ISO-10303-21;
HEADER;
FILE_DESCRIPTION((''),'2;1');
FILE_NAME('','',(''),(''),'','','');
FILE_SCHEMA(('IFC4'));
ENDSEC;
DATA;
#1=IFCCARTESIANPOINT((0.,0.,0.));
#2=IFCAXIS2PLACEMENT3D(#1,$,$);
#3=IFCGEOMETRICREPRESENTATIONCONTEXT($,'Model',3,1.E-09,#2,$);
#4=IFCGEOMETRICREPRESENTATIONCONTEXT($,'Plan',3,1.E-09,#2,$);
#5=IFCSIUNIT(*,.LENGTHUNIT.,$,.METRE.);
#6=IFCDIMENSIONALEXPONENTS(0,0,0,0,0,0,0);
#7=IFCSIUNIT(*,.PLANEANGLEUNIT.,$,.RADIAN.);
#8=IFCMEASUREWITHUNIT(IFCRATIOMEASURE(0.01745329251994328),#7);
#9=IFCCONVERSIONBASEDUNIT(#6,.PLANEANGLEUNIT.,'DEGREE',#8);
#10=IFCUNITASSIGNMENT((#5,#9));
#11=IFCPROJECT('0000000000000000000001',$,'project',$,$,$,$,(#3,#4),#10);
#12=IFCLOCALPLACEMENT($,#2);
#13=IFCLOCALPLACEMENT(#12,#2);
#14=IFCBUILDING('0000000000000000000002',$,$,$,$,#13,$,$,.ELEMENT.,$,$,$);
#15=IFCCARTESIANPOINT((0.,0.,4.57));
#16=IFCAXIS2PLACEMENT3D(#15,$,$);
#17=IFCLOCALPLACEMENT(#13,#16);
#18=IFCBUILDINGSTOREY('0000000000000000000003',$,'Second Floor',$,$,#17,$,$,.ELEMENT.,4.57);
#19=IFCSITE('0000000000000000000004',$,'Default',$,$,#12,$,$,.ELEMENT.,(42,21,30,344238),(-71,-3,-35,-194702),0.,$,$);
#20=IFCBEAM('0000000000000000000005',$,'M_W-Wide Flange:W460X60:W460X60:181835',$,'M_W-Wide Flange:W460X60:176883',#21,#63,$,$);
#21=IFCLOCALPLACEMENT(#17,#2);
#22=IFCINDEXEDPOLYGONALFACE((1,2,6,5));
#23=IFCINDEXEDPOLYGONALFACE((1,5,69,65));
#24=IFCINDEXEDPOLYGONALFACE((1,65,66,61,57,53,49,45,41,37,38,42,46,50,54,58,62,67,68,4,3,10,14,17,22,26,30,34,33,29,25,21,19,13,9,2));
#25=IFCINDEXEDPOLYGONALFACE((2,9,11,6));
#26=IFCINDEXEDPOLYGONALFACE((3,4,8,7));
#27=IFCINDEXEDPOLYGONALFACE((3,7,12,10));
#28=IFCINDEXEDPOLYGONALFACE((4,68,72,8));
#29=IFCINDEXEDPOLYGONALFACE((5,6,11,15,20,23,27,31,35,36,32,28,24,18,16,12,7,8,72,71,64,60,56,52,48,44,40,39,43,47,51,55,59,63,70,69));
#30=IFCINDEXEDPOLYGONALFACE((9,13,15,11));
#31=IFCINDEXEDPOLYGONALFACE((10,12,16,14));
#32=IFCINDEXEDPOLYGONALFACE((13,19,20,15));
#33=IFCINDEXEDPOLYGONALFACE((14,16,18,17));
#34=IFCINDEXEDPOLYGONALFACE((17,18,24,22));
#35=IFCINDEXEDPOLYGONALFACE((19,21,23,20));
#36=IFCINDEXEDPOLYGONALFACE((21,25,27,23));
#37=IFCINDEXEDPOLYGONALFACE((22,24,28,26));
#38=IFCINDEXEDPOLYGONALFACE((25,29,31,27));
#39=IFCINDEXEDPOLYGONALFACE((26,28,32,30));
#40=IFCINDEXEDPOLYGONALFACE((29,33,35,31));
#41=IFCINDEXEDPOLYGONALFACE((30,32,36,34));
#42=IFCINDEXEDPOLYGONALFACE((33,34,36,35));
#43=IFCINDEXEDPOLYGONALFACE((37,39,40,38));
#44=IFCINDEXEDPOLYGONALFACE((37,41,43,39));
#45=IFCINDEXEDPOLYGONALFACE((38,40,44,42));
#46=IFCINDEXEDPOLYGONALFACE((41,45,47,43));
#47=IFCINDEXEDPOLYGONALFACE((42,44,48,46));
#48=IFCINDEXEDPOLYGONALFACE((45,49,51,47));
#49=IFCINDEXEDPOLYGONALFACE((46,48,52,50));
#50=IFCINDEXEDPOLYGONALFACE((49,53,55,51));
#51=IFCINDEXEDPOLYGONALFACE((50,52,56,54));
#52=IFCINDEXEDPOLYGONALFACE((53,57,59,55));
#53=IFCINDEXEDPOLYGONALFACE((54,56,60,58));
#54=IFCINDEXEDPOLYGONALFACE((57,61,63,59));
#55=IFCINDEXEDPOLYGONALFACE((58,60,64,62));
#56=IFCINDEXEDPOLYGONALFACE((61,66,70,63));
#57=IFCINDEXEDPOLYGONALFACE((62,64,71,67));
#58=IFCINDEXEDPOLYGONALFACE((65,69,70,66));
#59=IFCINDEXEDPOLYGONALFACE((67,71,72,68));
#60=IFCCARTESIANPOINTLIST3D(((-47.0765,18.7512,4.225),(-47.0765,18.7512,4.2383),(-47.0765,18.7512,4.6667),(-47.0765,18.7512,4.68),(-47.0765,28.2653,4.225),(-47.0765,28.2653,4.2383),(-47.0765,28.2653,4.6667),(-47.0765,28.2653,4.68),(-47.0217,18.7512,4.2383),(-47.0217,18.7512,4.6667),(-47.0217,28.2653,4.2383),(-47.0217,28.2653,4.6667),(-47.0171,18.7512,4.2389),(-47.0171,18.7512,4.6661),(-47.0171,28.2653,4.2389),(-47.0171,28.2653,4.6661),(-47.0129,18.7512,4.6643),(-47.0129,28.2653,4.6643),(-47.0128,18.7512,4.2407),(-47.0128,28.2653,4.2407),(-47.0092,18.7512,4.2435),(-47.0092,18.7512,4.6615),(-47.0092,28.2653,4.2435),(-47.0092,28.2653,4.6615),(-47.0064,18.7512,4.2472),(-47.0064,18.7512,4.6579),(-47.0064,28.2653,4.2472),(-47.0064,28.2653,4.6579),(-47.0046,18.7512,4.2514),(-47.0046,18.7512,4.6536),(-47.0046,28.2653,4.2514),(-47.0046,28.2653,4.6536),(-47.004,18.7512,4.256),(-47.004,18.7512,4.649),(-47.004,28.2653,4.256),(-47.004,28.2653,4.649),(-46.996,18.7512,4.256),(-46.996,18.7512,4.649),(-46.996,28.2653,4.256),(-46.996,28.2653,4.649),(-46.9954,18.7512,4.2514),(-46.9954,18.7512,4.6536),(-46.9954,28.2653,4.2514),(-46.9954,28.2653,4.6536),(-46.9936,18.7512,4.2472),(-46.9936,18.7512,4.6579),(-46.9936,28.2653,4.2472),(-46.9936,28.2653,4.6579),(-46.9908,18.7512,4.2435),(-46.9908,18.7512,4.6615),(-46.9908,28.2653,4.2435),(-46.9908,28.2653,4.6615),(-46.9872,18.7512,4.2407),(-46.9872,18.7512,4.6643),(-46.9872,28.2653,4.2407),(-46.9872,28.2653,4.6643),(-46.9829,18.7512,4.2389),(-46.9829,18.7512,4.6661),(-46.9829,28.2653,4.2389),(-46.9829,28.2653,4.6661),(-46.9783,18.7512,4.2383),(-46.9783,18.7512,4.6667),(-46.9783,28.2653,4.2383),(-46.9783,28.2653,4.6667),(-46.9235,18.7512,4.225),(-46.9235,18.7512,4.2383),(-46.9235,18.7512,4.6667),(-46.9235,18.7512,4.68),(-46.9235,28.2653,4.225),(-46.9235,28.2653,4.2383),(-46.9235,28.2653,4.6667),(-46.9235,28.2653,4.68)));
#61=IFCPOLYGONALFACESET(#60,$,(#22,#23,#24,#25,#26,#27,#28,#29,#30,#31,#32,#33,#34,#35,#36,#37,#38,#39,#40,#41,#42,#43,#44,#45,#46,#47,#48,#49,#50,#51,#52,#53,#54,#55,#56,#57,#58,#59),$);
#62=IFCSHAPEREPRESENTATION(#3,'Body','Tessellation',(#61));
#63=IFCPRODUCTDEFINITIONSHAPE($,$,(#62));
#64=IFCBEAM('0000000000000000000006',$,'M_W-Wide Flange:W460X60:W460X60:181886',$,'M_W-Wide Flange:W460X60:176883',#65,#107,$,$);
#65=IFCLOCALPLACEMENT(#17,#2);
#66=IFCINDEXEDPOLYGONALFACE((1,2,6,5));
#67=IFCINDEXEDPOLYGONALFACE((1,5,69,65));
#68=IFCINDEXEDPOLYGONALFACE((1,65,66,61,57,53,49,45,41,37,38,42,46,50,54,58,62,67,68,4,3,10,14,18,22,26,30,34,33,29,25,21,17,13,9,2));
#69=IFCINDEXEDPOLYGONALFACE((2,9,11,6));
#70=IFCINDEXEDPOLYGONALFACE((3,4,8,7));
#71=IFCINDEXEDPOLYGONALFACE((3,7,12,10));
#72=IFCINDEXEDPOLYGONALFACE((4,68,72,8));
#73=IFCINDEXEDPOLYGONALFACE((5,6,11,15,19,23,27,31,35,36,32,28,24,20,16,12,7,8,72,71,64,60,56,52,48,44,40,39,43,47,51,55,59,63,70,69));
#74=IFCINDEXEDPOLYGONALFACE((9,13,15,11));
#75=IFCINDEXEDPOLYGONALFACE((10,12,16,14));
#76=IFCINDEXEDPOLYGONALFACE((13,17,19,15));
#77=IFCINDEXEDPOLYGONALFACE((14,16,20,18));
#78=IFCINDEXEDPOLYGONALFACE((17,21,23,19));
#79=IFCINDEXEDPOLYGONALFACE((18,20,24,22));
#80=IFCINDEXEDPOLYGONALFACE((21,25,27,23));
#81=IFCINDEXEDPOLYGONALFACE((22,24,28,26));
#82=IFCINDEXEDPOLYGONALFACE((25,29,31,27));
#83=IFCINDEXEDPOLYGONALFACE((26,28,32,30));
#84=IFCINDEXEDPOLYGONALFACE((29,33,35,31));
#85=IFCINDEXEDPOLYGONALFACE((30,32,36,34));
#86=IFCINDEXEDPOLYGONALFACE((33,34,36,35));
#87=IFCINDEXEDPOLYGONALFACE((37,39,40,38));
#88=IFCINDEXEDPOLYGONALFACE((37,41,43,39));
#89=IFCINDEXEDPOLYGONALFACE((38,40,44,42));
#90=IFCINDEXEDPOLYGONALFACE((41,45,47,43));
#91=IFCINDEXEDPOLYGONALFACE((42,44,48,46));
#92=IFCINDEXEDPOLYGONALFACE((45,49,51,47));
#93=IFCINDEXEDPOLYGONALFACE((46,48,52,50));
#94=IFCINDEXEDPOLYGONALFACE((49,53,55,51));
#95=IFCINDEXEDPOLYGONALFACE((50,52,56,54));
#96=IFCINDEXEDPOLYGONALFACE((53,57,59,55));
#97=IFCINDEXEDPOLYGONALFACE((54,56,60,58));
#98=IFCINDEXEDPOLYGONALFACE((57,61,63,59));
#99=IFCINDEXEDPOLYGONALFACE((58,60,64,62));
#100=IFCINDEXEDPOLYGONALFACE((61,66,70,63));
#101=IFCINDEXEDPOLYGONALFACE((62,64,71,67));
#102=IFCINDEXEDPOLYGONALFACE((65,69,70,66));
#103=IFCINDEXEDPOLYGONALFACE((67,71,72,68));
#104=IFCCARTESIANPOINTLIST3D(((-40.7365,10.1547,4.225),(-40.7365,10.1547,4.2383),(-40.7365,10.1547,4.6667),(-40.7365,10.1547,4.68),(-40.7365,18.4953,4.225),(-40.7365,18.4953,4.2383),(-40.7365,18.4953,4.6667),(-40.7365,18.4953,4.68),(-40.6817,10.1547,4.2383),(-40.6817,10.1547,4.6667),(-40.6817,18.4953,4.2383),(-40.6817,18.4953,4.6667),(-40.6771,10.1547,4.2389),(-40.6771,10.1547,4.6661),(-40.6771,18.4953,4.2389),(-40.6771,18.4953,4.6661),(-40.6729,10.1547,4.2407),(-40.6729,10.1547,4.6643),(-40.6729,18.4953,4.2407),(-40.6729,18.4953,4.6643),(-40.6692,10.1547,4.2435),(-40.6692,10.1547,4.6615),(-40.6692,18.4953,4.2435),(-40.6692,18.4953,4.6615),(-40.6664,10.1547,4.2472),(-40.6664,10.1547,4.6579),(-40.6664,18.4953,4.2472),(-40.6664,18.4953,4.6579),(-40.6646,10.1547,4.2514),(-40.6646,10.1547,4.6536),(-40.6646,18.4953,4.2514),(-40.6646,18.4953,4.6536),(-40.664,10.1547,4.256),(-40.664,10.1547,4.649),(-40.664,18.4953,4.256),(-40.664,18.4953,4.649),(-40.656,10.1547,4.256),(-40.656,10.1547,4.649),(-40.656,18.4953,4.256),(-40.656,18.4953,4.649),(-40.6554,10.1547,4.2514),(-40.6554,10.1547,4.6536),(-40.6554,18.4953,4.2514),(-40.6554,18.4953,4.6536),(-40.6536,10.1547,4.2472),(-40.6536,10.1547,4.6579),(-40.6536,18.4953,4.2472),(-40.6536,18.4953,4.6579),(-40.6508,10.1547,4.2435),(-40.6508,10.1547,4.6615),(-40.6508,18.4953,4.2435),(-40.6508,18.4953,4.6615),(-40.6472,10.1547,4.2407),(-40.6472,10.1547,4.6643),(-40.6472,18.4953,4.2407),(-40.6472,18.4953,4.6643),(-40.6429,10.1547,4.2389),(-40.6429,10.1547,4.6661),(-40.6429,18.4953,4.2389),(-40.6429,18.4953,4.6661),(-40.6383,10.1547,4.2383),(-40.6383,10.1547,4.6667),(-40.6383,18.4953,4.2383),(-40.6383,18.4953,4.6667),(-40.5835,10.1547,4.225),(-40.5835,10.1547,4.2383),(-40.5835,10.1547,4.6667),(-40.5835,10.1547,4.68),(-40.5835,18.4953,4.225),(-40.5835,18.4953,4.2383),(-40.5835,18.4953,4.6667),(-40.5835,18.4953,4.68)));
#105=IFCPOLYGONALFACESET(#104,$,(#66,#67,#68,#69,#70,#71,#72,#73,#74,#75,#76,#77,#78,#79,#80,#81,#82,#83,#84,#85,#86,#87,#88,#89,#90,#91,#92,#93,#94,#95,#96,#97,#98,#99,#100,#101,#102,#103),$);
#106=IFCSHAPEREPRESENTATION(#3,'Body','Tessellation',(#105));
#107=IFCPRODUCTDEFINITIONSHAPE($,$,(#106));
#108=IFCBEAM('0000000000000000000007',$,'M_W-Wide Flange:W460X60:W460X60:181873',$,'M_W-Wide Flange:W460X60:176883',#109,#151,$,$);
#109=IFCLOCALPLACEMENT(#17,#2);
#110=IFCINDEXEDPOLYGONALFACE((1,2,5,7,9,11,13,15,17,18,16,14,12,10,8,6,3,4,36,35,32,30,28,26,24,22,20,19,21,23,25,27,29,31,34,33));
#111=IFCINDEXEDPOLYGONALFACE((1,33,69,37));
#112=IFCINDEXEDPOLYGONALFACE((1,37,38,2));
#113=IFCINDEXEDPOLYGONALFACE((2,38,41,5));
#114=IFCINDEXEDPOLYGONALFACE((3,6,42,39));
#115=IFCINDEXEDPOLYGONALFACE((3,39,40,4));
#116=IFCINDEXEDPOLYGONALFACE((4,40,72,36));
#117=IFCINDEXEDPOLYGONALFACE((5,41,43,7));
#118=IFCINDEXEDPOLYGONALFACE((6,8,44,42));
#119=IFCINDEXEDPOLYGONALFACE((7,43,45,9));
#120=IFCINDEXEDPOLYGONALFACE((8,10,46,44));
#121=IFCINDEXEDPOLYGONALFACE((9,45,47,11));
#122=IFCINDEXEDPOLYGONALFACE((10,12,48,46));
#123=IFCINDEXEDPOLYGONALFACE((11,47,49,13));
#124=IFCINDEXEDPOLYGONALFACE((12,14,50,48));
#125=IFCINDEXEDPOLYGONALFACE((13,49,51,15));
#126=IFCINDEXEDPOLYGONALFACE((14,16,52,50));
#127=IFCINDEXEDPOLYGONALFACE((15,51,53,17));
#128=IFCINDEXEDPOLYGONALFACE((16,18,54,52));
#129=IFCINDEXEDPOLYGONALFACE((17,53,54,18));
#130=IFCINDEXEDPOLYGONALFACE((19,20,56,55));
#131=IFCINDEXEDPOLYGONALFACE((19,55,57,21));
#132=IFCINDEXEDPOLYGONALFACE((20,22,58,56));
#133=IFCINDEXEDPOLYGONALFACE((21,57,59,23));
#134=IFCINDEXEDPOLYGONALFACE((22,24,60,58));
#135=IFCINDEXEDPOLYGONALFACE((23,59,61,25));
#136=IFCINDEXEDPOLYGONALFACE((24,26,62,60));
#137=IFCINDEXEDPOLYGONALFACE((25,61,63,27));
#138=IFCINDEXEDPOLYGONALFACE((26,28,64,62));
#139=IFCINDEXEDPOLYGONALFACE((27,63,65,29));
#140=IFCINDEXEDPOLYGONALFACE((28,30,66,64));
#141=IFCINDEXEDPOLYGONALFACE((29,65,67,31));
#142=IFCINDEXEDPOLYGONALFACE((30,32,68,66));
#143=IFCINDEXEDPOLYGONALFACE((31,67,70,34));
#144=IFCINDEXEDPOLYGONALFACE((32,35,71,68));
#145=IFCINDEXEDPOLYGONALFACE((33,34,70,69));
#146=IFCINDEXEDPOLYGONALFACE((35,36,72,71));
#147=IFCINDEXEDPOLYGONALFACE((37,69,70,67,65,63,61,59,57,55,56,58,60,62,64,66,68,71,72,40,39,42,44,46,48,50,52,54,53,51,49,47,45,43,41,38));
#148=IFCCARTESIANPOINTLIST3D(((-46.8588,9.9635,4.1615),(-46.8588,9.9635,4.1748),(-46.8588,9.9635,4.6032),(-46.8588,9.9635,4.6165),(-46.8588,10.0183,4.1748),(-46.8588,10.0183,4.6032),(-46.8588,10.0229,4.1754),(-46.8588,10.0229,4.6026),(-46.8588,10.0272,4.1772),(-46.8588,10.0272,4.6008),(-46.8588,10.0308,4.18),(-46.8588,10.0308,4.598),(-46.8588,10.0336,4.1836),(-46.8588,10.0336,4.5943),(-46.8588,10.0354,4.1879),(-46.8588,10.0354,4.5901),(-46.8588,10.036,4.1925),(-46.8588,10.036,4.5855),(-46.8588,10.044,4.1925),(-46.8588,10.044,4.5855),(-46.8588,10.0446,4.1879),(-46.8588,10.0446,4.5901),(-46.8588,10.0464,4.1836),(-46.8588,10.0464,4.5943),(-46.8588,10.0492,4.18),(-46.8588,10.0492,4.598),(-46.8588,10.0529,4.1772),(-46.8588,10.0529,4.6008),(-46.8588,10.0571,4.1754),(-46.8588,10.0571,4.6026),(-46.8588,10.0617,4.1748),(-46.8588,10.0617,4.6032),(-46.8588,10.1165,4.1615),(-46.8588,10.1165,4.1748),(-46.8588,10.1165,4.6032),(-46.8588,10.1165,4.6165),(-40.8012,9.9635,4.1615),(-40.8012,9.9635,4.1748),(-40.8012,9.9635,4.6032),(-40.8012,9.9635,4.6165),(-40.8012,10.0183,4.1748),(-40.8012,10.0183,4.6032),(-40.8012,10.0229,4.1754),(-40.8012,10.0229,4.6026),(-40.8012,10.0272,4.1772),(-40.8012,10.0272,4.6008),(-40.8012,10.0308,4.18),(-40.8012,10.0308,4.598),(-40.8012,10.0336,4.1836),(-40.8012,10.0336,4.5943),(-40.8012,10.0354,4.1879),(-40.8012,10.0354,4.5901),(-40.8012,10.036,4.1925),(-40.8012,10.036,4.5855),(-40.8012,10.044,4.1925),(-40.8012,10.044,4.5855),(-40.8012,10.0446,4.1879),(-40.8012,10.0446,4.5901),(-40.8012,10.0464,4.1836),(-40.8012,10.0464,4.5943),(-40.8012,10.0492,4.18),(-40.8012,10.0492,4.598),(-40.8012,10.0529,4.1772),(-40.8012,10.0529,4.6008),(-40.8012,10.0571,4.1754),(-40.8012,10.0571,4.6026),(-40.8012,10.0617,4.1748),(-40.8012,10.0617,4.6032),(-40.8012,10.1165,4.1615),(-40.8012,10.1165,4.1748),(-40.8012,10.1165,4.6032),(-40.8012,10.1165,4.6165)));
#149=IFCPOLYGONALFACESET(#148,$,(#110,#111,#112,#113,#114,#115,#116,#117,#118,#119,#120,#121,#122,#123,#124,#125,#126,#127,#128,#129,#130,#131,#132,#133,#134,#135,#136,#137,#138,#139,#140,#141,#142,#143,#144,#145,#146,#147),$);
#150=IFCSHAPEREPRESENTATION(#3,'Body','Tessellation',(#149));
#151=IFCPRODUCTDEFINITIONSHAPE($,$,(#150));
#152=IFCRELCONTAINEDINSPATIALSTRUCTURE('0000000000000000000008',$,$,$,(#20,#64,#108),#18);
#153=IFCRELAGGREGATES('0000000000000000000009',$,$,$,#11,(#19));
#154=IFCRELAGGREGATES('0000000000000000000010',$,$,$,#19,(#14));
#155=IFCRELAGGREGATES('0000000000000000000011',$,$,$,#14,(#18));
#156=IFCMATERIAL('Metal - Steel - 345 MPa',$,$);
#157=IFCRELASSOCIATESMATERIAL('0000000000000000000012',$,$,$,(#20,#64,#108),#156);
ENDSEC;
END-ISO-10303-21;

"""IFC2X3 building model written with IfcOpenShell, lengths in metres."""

from ifc_helpers import new_model, entity, si_unit, converted_unit, frame, frame_2d, origin, place, context, project, spatial, polyline, circle_curve, parameter, trimmed, segment, composite_curve, outline, extrude, material, element, save


model = new_model("IFC2X3")

# Units and contexts
model_context = context("Model", 3, precision=1e-09, world=origin())
plan_context = context("Plan", 3, precision=1e-09, world=origin())
ifc_project = project(units=[si_unit("LENGTHUNIT", "METRE"), converted_unit("PLANEANGLEUNIT", "DEGREE", entity("IfcRatioMeasure", 0.01745329251994328), si_unit("PLANEANGLEUNIT", "RADIAN"), dimensions=[0, 0, 0, 0, 0, 0, 0])], contexts=[model_context, plan_context])

# Site, building, storey
site_placement = place(None, origin())
site = spatial("IfcSite", under=ifc_project, at=site_placement, Name="Default", CompositionType="ELEMENT", RefLatitude=(42, 21, 30, 344238), RefLongitude=(-71, -3, -35, -194702), RefElevation=0.0)
building_placement = place(site_placement, origin())
building = spatial("IfcBuilding", under=site, at=building_placement, CompositionType="ELEMENT")
storey_placement = place(building_placement, frame((0.0, 0.0, 4.57)))
storey = spatial("IfcBuildingStorey", under=building, at=storey_placement, Name="Second Floor", CompositionType="ELEMENT", Elevation=4.57)

# Shared definitions
ifc_material_1 = material(Name="Metal - Steel - 345 MPa")

# Beams
beam_1_placement = place(storey_placement, frame((-47.0, 28.3781, 4.68), z_axis=(0.0, 0.0, 1.0), x_axis=(-1.0, 0.0, 0.0)))
element("IfcBeam", 1, at=beam_1_placement, inside=storey, material=ifc_material_1, Name="M_W-Wide Flange:W460X60:W460X60:181835", ObjectType="M_W-Wide Flange:W460X60:176883", context=model_context, shape_type="SweptSolid", body=[
    extrude(outline(composite_curve([segment(polyline([(0.2142, -0.0765), (0.2275, -0.0765)]), True, "CONTINUOUS"), segment(polyline([(0.2275, -0.0765), (0.2275, 0.0765)]), True, "CONTINUOUS"), segment(polyline([(0.2275, 0.0765), (0.2142, 0.0765)]), True, "CONTINUOUS"), segment(polyline([(0.2142, 0.0765), (0.2142, 0.0217)]), True, "CONTINUOUS"), segment(trimmed(circle_curve(frame_2d((0.1965, 0.0217), x_axis=(1.0, 0.0)), 0.0177), [parameter(270.0)], [parameter(360.0)], True, "PARAMETER"), False, "CONTINUOUS"), segment(polyline([(0.1965, 0.004), (-0.1965, 0.004)]), True, "CONTINUOUS"), segment(trimmed(circle_curve(frame_2d((-0.1965, 0.0217), x_axis=(0.0, -1.0)), 0.0177), [parameter(270.0)], [parameter(360.0)], True, "PARAMETER"), False, "CONTINUOUS"), segment(polyline([(-0.2142, 0.0217), (-0.2142, 0.0765)]), True, "CONTINUOUS"), segment(polyline([(-0.2142, 0.0765), (-0.2275, 0.0765)]), True, "CONTINUOUS"), segment(polyline([(-0.2275, 0.0765), (-0.2275, -0.0765)]), True, "CONTINUOUS"), segment(polyline([(-0.2275, -0.0765), (-0.2142, -0.0765)]), True, "CONTINUOUS"), segment(polyline([(-0.2142, -0.0765), (-0.2142, -0.0217)]), True, "CONTINUOUS"), segment(trimmed(circle_curve(frame_2d((-0.1965, -0.0217), x_axis=(-1.0, 0.0)), 0.0177), [parameter(270.0)], [parameter(360.0)], True, "PARAMETER"), False, "CONTINUOUS"), segment(polyline([(-0.1965, -0.004), (0.1965, -0.004)]), True, "CONTINUOUS"), segment(trimmed(circle_curve(frame_2d((0.1965, -0.0217), x_axis=(0.0, 1.0)), 0.0177), [parameter(270.0)], [parameter(0.0)], True, "PARAMETER"), False, "CONTINUOUS"), segment(polyline([(0.2142, -0.0217), (0.2142, -0.0765)]), True, "CONTINUOUS")], self_intersect=False)), frame((0.0, 9.6269, -0.2275), z_axis=(0.0, -1.0, 0.0), x_axis=(0.0, 0.0, -1.0)), (0.0, 0.0, 1.0), 9.5141),
])
beam_2_placement = place(storey_placement, frame((-40.66, 10.0422, 4.68)))
element("IfcBeam", 2, at=beam_2_placement, inside=storey, material=ifc_material_1, Name="M_W-Wide Flange:W460X60:W460X60:181886", ObjectType="M_W-Wide Flange:W460X60:176883", context=model_context, shape_type="SweptSolid", body=[
    extrude(outline(composite_curve([segment(polyline([(-0.0765, -0.2142), (-0.0765, -0.2275)]), True, "CONTINUOUS"), segment(polyline([(-0.0765, -0.2275), (0.0765, -0.2275)]), True, "CONTINUOUS"), segment(polyline([(0.0765, -0.2275), (0.0765, -0.2142)]), True, "CONTINUOUS"), segment(polyline([(0.0765, -0.2142), (0.0217, -0.2142)]), True, "CONTINUOUS"), segment(trimmed(circle_curve(frame_2d((0.0217, -0.1965), x_axis=(0.0, -1.0)), 0.0177), [parameter(270.0)], [parameter(360.0)], True, "PARAMETER"), False, "CONTINUOUS"), segment(polyline([(0.004, -0.1965), (0.004, 0.1965)]), True, "CONTINUOUS"), segment(trimmed(circle_curve(frame_2d((0.0217, 0.1965), x_axis=(-1.0, 0.0)), 0.0177), [parameter(270.0)], [parameter(360.0)], True, "PARAMETER"), False, "CONTINUOUS"), segment(polyline([(0.0217, 0.2142), (0.0765, 0.2142)]), True, "CONTINUOUS"), segment(polyline([(0.0765, 0.2142), (0.0765, 0.2275)]), True, "CONTINUOUS"), segment(polyline([(0.0765, 0.2275), (-0.0765, 0.2275)]), True, "CONTINUOUS"), segment(polyline([(-0.0765, 0.2275), (-0.0765, 0.2142)]), True, "CONTINUOUS"), segment(polyline([(-0.0765, 0.2142), (-0.0217, 0.2142)]), True, "CONTINUOUS"), segment(trimmed(circle_curve(frame_2d((-0.0217, 0.1965), x_axis=(0.0, 1.0)), 0.0177), [parameter(270.0)], [parameter(360.0)], True, "PARAMETER"), False, "CONTINUOUS"), segment(polyline([(-0.004, 0.1965), (-0.004, -0.1965)]), True, "CONTINUOUS"), segment(trimmed(circle_curve(frame_2d((-0.0217, -0.1965), x_axis=(1.0, 0.0)), 0.0177), [parameter(270.0)], [parameter(0.0)], True, "PARAMETER"), False, "CONTINUOUS"), segment(polyline([(-0.0217, -0.2142), (-0.0765, -0.2142)]), True, "CONTINUOUS")], self_intersect=False)), frame((0.0, 0.1125, -0.2275), z_axis=(0.0, -1.0, 0.0), x_axis=(1.0, 0.0, 0.0)), (0.0, 0.0, -1.0), 8.3406),
])
beam_3_placement = place(storey_placement, frame((-46.997, 10.04, 4.6165), z_axis=(0.0, 0.0, 1.0), x_axis=(0.0, -1.0, 0.0)))
element("IfcBeam", 3, at=beam_3_placement, inside=storey, material=ifc_material_1, Name="M_W-Wide Flange:W460X60:W460X60:181873", ObjectType="M_W-Wide Flange:W460X60:176883", context=model_context, shape_type="SweptSolid", body=[
    extrude(outline(composite_curve([segment(polyline([(-0.0765, -0.2142), (-0.0765, -0.2275)]), True, "CONTINUOUS"), segment(polyline([(-0.0765, -0.2275), (0.0765, -0.2275)]), True, "CONTINUOUS"), segment(polyline([(0.0765, -0.2275), (0.0765, -0.2142)]), True, "CONTINUOUS"), segment(polyline([(0.0765, -0.2142), (0.0217, -0.2142)]), True, "CONTINUOUS"), segment(trimmed(circle_curve(frame_2d((0.0217, -0.1965), x_axis=(1.0, 0.0)), 0.0177), [parameter(180.0)], [parameter(270.0)], True, "PARAMETER"), False, "CONTINUOUS"), segment(polyline([(0.004, -0.1965), (0.004, 0.1965)]), True, "CONTINUOUS"), segment(trimmed(circle_curve(frame_2d((0.0217, 0.1965), x_axis=(1.0, 0.0)), 0.0177), [parameter(90.0)], [parameter(180.0)], True, "PARAMETER"), False, "CONTINUOUS"), segment(polyline([(0.0217, 0.2142), (0.0765, 0.2142)]), True, "CONTINUOUS"), segment(polyline([(0.0765, 0.2142), (0.0765, 0.2275)]), True, "CONTINUOUS"), segment(polyline([(0.0765, 0.2275), (-0.0765, 0.2275)]), True, "CONTINUOUS"), segment(polyline([(-0.0765, 0.2275), (-0.0765, 0.2142)]), True, "CONTINUOUS"), segment(polyline([(-0.0765, 0.2142), (-0.0217, 0.2142)]), True, "CONTINUOUS"), segment(trimmed(circle_curve(frame_2d((-0.0217, 0.1965), x_axis=(1.0, 0.0)), 0.0177), [parameter(360.0)], [parameter(90.0)], True, "PARAMETER"), False, "CONTINUOUS"), segment(polyline([(-0.004, 0.1965), (-0.004, -0.1965)]), True, "CONTINUOUS"), segment(trimmed(circle_curve(frame_2d((-0.0217, -0.1965), x_axis=(1.0, 0.0)), 0.0177), [parameter(270.0)], [parameter(0.0)], True, "PARAMETER"), False, "CONTINUOUS"), segment(polyline([(-0.0217, -0.2142), (-0.0765, -0.2142)]), True, "CONTINUOUS")], self_intersect=False)), frame((0.0, 0.1382, -0.2275), z_axis=(0.0, -1.0, 0.0), x_axis=(1.0, 0.0, 0.0)), (0.0, 0.0, -1.0), 6.0576),
])

save(model, "model.ifc")
